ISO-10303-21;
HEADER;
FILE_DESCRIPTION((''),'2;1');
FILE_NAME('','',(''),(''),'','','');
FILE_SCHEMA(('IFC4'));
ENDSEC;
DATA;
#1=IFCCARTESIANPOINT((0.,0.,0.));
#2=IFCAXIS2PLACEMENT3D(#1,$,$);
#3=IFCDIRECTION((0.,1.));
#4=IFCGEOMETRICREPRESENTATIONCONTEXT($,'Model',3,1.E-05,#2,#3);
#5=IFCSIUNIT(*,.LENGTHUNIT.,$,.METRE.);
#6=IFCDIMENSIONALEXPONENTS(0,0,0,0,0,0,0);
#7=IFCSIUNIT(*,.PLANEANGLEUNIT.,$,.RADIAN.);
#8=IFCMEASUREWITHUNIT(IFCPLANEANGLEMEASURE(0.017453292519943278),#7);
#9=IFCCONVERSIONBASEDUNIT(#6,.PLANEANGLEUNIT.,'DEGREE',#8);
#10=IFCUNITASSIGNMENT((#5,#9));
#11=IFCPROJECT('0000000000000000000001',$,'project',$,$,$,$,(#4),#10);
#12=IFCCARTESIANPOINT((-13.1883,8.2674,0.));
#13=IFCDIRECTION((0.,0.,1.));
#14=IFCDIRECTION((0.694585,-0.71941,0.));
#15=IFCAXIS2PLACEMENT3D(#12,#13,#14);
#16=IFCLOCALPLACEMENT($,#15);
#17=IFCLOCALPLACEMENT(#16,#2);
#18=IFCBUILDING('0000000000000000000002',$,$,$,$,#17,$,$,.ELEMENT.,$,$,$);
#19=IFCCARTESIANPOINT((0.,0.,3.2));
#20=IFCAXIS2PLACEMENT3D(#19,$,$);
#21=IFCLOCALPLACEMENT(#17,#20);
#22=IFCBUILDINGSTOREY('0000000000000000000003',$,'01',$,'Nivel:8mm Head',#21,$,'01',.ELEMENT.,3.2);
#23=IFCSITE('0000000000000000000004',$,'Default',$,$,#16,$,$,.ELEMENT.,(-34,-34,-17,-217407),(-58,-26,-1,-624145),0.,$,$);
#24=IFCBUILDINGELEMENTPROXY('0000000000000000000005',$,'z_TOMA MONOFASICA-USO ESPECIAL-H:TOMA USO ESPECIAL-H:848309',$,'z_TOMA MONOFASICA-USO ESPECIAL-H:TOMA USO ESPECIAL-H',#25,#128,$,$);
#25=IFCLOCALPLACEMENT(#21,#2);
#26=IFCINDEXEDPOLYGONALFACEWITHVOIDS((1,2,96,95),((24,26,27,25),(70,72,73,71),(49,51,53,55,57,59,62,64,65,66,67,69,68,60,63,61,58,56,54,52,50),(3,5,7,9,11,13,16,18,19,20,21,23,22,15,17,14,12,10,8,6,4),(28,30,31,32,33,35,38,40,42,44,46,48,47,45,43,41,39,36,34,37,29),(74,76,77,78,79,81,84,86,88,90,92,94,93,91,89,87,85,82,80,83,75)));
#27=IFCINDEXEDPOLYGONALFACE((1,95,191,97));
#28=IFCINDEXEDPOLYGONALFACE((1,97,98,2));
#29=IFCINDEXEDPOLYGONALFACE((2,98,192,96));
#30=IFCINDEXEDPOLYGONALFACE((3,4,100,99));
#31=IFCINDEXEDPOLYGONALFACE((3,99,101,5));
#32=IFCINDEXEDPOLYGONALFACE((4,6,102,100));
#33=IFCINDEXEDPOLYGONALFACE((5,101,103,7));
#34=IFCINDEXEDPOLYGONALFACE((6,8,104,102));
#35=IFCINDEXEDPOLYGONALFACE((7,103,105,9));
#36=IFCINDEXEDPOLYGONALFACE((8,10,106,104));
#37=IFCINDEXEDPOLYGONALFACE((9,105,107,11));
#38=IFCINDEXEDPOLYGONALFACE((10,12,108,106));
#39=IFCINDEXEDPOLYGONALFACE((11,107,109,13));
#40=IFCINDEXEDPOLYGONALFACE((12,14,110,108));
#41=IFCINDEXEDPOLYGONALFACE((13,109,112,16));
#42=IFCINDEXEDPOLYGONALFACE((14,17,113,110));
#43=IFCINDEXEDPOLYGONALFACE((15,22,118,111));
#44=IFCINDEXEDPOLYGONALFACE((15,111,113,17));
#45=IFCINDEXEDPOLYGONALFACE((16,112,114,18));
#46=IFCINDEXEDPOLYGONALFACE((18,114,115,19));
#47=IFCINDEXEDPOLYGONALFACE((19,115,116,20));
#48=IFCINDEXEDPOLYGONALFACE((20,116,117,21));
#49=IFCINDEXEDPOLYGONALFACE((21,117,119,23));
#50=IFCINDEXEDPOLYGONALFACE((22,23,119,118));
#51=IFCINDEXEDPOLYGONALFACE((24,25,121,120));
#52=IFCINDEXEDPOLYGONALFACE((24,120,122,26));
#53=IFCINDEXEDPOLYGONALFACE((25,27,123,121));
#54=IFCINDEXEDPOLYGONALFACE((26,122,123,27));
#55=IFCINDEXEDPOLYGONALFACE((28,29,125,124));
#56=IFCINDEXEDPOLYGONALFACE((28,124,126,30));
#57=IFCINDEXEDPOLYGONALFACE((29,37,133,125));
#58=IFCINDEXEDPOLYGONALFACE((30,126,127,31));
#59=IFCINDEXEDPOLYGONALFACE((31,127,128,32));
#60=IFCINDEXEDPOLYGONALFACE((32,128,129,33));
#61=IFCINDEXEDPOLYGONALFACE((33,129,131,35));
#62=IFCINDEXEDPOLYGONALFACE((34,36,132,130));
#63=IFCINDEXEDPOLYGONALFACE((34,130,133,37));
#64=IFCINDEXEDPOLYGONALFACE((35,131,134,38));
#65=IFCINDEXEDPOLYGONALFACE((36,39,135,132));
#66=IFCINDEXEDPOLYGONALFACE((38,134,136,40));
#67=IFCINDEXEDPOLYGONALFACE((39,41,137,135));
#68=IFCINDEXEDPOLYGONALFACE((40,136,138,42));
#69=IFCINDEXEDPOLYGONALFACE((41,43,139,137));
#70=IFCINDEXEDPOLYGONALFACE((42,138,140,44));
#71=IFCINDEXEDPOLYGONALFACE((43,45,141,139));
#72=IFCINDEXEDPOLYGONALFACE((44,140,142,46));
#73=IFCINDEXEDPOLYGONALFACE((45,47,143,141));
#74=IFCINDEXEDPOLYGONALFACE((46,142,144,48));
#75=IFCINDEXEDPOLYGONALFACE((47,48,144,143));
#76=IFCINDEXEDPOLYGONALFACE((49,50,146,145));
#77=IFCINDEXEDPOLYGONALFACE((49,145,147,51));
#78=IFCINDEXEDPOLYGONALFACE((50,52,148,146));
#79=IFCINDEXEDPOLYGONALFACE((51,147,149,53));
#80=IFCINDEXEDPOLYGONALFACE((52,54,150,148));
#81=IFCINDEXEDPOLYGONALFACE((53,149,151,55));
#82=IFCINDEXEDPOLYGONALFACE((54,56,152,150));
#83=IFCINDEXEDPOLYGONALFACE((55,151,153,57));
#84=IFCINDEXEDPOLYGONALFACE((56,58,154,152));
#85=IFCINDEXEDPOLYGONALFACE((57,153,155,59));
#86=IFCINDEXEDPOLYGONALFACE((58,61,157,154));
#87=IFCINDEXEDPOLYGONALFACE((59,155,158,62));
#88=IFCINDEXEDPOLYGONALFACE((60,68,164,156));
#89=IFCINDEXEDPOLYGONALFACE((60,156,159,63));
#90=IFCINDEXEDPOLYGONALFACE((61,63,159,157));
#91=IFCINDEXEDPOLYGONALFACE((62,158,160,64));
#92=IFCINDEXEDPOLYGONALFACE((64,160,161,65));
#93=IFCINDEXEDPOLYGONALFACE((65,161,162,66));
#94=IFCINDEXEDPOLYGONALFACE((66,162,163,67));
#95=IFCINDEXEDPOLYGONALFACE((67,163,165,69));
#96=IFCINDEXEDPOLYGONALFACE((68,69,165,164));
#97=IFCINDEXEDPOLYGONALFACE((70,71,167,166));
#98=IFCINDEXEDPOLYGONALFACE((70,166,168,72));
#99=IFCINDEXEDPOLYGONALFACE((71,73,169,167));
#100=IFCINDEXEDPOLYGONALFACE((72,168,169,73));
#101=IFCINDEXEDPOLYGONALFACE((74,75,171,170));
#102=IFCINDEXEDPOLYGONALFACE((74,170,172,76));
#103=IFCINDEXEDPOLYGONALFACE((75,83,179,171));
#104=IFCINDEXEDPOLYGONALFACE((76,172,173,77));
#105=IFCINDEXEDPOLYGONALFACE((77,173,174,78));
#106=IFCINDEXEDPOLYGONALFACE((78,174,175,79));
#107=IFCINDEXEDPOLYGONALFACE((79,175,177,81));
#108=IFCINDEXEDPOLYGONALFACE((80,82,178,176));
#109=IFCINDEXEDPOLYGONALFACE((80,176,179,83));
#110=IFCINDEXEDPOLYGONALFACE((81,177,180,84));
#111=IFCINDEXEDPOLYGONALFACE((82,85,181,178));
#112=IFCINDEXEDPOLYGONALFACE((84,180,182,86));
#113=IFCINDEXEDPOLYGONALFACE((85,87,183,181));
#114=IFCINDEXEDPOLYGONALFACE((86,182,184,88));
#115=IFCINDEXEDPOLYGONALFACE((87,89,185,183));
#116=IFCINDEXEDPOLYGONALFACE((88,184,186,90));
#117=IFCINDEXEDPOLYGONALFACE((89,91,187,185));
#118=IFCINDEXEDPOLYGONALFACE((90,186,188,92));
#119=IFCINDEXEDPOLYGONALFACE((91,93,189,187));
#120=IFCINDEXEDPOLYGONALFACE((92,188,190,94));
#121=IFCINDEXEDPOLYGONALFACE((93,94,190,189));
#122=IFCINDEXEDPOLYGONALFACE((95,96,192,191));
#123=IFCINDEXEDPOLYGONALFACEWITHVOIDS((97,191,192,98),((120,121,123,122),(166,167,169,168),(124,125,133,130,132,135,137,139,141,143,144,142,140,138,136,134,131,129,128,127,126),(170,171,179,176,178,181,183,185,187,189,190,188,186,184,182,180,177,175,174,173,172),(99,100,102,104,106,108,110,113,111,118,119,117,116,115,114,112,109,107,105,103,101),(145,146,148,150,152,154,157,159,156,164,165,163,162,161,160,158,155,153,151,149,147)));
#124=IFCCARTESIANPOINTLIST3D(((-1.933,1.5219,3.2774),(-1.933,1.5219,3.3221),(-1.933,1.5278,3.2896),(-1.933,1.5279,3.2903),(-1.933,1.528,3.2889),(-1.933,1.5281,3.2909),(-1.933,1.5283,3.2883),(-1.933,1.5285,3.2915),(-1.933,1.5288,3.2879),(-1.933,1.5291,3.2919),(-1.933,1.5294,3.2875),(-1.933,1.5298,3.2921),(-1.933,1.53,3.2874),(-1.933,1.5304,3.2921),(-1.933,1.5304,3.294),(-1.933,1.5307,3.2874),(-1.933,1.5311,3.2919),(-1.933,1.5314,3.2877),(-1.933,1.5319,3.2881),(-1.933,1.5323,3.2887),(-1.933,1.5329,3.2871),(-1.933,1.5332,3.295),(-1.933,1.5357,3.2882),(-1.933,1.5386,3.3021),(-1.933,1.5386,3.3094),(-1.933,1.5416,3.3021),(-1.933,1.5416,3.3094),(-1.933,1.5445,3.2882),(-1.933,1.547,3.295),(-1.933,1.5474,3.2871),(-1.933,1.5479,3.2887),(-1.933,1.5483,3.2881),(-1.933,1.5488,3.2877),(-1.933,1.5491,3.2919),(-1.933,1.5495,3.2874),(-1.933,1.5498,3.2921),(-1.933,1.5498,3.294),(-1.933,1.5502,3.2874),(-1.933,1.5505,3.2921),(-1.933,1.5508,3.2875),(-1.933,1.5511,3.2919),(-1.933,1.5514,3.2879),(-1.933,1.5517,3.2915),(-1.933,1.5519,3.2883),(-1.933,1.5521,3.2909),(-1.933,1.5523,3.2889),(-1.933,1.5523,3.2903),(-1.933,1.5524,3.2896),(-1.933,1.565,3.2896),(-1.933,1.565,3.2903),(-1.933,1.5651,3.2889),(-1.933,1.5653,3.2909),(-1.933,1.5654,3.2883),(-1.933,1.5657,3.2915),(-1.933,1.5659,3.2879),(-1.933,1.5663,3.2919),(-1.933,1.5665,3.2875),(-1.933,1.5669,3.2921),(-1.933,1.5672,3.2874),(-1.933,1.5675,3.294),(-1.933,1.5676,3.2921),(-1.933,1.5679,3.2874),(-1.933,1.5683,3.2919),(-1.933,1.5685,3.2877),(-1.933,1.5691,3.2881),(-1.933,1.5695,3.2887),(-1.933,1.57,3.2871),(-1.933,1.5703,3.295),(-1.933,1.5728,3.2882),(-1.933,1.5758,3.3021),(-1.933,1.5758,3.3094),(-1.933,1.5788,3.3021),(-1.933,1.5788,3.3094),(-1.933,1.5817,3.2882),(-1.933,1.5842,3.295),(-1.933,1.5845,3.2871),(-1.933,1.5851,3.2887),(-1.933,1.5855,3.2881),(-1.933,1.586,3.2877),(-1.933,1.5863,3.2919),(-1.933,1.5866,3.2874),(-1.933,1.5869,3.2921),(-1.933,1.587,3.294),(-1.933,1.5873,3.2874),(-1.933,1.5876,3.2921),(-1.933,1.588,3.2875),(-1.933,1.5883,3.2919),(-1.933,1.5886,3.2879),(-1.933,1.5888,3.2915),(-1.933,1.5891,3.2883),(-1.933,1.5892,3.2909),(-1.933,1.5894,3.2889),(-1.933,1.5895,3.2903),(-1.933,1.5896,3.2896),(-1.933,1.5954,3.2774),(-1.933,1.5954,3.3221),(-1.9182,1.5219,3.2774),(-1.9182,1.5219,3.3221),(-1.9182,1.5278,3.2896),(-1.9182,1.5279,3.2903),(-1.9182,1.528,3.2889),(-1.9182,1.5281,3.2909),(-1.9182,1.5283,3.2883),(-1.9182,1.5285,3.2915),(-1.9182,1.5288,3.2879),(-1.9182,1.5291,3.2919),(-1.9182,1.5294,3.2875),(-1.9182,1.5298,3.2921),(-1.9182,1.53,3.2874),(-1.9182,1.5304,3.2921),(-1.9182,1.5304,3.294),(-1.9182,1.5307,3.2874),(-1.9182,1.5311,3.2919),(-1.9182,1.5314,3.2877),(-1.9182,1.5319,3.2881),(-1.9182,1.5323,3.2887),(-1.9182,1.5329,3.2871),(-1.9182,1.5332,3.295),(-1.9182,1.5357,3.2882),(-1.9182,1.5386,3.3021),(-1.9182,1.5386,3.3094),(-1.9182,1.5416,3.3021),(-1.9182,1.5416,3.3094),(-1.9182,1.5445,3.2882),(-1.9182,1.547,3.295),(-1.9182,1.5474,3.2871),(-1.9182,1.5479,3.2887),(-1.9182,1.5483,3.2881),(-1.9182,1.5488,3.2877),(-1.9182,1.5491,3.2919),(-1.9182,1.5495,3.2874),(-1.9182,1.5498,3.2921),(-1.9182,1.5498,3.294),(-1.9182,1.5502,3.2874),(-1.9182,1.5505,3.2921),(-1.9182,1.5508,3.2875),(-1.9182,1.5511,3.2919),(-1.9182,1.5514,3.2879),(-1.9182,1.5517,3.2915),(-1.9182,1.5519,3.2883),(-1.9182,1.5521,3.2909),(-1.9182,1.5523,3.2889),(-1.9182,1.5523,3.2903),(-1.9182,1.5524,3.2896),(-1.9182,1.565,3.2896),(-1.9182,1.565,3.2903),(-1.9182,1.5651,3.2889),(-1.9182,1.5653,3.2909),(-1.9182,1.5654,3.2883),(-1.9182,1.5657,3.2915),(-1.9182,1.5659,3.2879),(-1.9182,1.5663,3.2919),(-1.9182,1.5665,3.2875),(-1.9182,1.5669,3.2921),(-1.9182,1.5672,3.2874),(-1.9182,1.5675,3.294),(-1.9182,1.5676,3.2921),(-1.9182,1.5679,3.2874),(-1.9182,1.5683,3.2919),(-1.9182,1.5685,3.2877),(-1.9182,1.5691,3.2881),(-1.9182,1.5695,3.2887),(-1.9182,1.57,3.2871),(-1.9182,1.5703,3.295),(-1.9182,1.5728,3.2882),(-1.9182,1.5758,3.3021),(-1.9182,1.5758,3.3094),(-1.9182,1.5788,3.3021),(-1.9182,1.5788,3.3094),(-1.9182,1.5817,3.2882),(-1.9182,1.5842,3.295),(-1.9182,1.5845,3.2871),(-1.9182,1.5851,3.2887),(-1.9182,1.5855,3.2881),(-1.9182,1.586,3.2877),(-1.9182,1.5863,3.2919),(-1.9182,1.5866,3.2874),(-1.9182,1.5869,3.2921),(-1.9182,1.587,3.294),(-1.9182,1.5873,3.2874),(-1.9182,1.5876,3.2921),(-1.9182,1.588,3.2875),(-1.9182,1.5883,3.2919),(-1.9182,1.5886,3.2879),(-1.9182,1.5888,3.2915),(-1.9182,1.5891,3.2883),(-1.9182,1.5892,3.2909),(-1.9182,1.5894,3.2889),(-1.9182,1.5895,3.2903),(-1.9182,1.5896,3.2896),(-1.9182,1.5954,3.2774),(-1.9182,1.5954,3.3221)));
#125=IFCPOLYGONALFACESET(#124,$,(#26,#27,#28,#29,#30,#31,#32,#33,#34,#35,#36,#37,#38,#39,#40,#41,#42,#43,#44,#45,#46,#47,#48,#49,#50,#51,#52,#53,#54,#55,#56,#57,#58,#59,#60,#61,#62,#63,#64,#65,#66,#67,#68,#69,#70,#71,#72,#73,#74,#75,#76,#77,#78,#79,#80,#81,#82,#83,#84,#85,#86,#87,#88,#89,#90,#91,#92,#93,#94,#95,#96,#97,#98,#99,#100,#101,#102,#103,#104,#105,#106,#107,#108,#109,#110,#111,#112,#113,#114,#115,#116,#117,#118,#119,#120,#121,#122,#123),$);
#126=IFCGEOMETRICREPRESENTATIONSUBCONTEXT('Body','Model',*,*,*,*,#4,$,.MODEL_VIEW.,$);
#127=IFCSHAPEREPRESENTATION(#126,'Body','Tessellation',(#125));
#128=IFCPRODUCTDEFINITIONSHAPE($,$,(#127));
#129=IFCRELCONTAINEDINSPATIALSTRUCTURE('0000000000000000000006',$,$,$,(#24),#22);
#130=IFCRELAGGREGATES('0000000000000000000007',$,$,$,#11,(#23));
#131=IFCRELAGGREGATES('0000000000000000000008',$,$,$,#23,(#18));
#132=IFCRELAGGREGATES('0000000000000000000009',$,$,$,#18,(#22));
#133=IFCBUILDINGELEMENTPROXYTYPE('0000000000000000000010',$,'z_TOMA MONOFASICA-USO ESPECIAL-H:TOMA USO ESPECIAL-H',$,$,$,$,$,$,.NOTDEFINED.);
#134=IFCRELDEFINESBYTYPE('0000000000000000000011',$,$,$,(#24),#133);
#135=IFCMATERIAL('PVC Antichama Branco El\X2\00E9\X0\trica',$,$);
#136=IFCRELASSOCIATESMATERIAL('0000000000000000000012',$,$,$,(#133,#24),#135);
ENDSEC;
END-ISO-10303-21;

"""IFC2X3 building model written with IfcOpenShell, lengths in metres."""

from ifc_helpers import new_model, entity, si_unit, converted_unit, direction, frame, frame_2d, origin, place, context, subcontext, project, spatial, polyline, circle_curve, parameter, trimmed, segment, composite_curve, outline, extrude, source, transform, mapped, material, type_object, type_shapes, element, save


model = new_model("IFC2X3")

# Units and contexts
model_context = context("Model", 3, precision=1e-05, world=origin(), true_north=direction((0.0, 1.0)))
body_context = subcontext(model_context, "Body", "Model", "MODEL_VIEW")
ifc_project = project(units=[si_unit("LENGTHUNIT", "METRE"), converted_unit("PLANEANGLEUNIT", "DEGREE", entity("IfcPlaneAngleMeasure", 0.017453292519943278), si_unit("PLANEANGLEUNIT", "RADIAN"), dimensions=[0, 0, 0, 0, 0, 0, 0])], contexts=[model_context])

# Site, building, storey
site_placement = place(None, frame((-13.1883, 8.2674, 0.0), z_axis=(0.0, 0.0, 1.0), x_axis=(0.694585, -0.71941, 0.0)))
site = spatial("IfcSite", under=ifc_project, at=site_placement, Name="Default", CompositionType="ELEMENT", RefLatitude=(-34, -34, -17, -217407), RefLongitude=(-58, -26, -1, -624145), RefElevation=0.0)
building_placement = place(site_placement, origin())
building = spatial("IfcBuilding", under=site, at=building_placement, CompositionType="ELEMENT")
storey_placement = place(building_placement, frame((0.0, 0.0, 3.2)))
storey = spatial("IfcBuildingStorey", under=building, at=storey_placement, Name="01", ObjectType="Nivel:8mm Head", LongName="01", CompositionType="ELEMENT", Elevation=3.2)

# Building element proxy
ifc_material_1 = material(Name="PVC Antichama Branco Elétrica")
building_element_proxy_type_1 = type_object("IfcBuildingElementProxyType", Name="z_TOMA MONOFASICA-USO ESPECIAL-H:TOMA USO ESPECIAL-H", PredefinedType="NOTDEFINED", material=ifc_material_1)
shared_shape_1 = source(origin(), body_context, "Body", "SweptSolid", [
    extrude(outline(polyline([(-0.0368, -0.0223), (0.0368, -0.0223), (0.0368, 0.0223), (-0.0368, 0.0223), (-0.0368, -0.0223)]), holes=[composite_curve([segment(polyline([(0.0141, 0.0115), (0.0116, 0.0047)]), True, "CONTINUOUS"), segment(polyline([(0.0116, 0.0047), (0.0088, 0.0057)]), True, "CONTINUOUS"), segment(polyline([(0.0088, 0.0057), (0.0096, 0.0078)]), True, "CONTINUOUS"), segment(trimmed(circle_curve(frame_2d((0.0087, 0.0099), x_axis=(1.0, 0.0)), 0.0024), [parameter(27.118901)], [parameter(292.881099)], True, "PARAMETER"), False, "CONTINUOUS"), segment(polyline([(0.0108, 0.011), (0.0113, 0.0126)]), True, "CONTINUOUS"), segment(polyline([(0.0113, 0.0126), (0.0141, 0.0115)]), True, "CONTINUOUS")], self_intersect=False), composite_curve([segment(polyline([(0.0255, 0.0047), (0.023, 0.0115)]), True, "CONTINUOUS"), segment(polyline([(0.023, 0.0115), (0.0258, 0.0126)]), True, "CONTINUOUS"), segment(polyline([(0.0258, 0.0126), (0.0264, 0.011)]), True, "CONTINUOUS"), segment(trimmed(circle_curve(frame_2d((0.0285, 0.0099), x_axis=(1.0, 0.0)), 0.0024), [parameter(247.118901)], [parameter(152.881099)], True, "PARAMETER"), False, "CONTINUOUS"), segment(polyline([(0.0276, 0.0078), (0.0283, 0.0057)]), True, "CONTINUOUS"), segment(polyline([(0.0283, 0.0057), (0.0255, 0.0047)]), True, "CONTINUOUS")], self_intersect=False), polyline([(0.0201, -0.0024), (0.0201, -0.0097), (0.0171, -0.0097), (0.0171, -0.0024), (0.0201, -0.0024)]), composite_curve([segment(polyline([(-0.0141, 0.0115), (-0.0113, 0.0126)]), True, "CONTINUOUS"), segment(polyline([(-0.0113, 0.0126), (-0.0108, 0.011)]), True, "CONTINUOUS"), segment(trimmed(circle_curve(frame_2d((-0.0087, 0.0099), x_axis=(1.0, 0.0)), 0.0024), [parameter(247.118901)], [parameter(152.881099)], True, "PARAMETER"), False, "CONTINUOUS"), segment(polyline([(-0.0096, 0.0078), (-0.0088, 0.0057)]), True, "CONTINUOUS"), segment(polyline([(-0.0088, 0.0057), (-0.0116, 0.0047)]), True, "CONTINUOUS"), segment(polyline([(-0.0116, 0.0047), (-0.0141, 0.0115)]), True, "CONTINUOUS")], self_intersect=False), composite_curve([segment(polyline([(-0.0255, 0.0047), (-0.0283, 0.0057)]), True, "CONTINUOUS"), segment(polyline([(-0.0283, 0.0057), (-0.0276, 0.0078)]), True, "CONTINUOUS"), segment(trimmed(circle_curve(frame_2d((-0.0285, 0.0099), x_axis=(1.0, 0.0)), 0.0024), [parameter(27.118901)], [parameter(292.881099)], True, "PARAMETER"), False, "CONTINUOUS"), segment(polyline([(-0.0264, 0.011), (-0.0258, 0.0126)]), True, "CONTINUOUS"), segment(polyline([(-0.0258, 0.0126), (-0.023, 0.0115)]), True, "CONTINUOUS"), segment(polyline([(-0.023, 0.0115), (-0.0255, 0.0047)]), True, "CONTINUOUS")], self_intersect=False), polyline([(-0.0201, -0.0024), (-0.0171, -0.0024), (-0.0171, -0.0097), (-0.0201, -0.0097), (-0.0201, -0.0024)])]), frame((0.0, -0.005, 0.0223), z_axis=(0.0, 1.0, 0.0), x_axis=(1.0, 0.0, 0.0)), (0.0, 0.0, 1.0), 0.0148),
])
type_shapes(building_element_proxy_type_1, [shared_shape_1])
for number, where, z_axis, x_axis, name in (
    (1, (-1.928, 1.5587, 3.2774), (0.0, 0.0, 1.0), (0.0, -1.0, 0.0), "z_TOMA MONOFASICA-USO ESPECIAL-H:TOMA USO ESPECIAL-H:848309"),
):
    element("IfcBuildingElementProxy", number, at=place(storey_placement, frame(where, z_axis=z_axis, x_axis=x_axis)), inside=storey, type_object=building_element_proxy_type_1, material=ifc_material_1, Name=name, ObjectType="z_TOMA MONOFASICA-USO ESPECIAL-H:TOMA USO ESPECIAL-H", context=body_context, shape_type="MappedRepresentation", body=[
        mapped(shared_shape_1, transform((0.0, 0.0, 0.0), scale=1.0)),
    ])

save(model, "model.ifc")
